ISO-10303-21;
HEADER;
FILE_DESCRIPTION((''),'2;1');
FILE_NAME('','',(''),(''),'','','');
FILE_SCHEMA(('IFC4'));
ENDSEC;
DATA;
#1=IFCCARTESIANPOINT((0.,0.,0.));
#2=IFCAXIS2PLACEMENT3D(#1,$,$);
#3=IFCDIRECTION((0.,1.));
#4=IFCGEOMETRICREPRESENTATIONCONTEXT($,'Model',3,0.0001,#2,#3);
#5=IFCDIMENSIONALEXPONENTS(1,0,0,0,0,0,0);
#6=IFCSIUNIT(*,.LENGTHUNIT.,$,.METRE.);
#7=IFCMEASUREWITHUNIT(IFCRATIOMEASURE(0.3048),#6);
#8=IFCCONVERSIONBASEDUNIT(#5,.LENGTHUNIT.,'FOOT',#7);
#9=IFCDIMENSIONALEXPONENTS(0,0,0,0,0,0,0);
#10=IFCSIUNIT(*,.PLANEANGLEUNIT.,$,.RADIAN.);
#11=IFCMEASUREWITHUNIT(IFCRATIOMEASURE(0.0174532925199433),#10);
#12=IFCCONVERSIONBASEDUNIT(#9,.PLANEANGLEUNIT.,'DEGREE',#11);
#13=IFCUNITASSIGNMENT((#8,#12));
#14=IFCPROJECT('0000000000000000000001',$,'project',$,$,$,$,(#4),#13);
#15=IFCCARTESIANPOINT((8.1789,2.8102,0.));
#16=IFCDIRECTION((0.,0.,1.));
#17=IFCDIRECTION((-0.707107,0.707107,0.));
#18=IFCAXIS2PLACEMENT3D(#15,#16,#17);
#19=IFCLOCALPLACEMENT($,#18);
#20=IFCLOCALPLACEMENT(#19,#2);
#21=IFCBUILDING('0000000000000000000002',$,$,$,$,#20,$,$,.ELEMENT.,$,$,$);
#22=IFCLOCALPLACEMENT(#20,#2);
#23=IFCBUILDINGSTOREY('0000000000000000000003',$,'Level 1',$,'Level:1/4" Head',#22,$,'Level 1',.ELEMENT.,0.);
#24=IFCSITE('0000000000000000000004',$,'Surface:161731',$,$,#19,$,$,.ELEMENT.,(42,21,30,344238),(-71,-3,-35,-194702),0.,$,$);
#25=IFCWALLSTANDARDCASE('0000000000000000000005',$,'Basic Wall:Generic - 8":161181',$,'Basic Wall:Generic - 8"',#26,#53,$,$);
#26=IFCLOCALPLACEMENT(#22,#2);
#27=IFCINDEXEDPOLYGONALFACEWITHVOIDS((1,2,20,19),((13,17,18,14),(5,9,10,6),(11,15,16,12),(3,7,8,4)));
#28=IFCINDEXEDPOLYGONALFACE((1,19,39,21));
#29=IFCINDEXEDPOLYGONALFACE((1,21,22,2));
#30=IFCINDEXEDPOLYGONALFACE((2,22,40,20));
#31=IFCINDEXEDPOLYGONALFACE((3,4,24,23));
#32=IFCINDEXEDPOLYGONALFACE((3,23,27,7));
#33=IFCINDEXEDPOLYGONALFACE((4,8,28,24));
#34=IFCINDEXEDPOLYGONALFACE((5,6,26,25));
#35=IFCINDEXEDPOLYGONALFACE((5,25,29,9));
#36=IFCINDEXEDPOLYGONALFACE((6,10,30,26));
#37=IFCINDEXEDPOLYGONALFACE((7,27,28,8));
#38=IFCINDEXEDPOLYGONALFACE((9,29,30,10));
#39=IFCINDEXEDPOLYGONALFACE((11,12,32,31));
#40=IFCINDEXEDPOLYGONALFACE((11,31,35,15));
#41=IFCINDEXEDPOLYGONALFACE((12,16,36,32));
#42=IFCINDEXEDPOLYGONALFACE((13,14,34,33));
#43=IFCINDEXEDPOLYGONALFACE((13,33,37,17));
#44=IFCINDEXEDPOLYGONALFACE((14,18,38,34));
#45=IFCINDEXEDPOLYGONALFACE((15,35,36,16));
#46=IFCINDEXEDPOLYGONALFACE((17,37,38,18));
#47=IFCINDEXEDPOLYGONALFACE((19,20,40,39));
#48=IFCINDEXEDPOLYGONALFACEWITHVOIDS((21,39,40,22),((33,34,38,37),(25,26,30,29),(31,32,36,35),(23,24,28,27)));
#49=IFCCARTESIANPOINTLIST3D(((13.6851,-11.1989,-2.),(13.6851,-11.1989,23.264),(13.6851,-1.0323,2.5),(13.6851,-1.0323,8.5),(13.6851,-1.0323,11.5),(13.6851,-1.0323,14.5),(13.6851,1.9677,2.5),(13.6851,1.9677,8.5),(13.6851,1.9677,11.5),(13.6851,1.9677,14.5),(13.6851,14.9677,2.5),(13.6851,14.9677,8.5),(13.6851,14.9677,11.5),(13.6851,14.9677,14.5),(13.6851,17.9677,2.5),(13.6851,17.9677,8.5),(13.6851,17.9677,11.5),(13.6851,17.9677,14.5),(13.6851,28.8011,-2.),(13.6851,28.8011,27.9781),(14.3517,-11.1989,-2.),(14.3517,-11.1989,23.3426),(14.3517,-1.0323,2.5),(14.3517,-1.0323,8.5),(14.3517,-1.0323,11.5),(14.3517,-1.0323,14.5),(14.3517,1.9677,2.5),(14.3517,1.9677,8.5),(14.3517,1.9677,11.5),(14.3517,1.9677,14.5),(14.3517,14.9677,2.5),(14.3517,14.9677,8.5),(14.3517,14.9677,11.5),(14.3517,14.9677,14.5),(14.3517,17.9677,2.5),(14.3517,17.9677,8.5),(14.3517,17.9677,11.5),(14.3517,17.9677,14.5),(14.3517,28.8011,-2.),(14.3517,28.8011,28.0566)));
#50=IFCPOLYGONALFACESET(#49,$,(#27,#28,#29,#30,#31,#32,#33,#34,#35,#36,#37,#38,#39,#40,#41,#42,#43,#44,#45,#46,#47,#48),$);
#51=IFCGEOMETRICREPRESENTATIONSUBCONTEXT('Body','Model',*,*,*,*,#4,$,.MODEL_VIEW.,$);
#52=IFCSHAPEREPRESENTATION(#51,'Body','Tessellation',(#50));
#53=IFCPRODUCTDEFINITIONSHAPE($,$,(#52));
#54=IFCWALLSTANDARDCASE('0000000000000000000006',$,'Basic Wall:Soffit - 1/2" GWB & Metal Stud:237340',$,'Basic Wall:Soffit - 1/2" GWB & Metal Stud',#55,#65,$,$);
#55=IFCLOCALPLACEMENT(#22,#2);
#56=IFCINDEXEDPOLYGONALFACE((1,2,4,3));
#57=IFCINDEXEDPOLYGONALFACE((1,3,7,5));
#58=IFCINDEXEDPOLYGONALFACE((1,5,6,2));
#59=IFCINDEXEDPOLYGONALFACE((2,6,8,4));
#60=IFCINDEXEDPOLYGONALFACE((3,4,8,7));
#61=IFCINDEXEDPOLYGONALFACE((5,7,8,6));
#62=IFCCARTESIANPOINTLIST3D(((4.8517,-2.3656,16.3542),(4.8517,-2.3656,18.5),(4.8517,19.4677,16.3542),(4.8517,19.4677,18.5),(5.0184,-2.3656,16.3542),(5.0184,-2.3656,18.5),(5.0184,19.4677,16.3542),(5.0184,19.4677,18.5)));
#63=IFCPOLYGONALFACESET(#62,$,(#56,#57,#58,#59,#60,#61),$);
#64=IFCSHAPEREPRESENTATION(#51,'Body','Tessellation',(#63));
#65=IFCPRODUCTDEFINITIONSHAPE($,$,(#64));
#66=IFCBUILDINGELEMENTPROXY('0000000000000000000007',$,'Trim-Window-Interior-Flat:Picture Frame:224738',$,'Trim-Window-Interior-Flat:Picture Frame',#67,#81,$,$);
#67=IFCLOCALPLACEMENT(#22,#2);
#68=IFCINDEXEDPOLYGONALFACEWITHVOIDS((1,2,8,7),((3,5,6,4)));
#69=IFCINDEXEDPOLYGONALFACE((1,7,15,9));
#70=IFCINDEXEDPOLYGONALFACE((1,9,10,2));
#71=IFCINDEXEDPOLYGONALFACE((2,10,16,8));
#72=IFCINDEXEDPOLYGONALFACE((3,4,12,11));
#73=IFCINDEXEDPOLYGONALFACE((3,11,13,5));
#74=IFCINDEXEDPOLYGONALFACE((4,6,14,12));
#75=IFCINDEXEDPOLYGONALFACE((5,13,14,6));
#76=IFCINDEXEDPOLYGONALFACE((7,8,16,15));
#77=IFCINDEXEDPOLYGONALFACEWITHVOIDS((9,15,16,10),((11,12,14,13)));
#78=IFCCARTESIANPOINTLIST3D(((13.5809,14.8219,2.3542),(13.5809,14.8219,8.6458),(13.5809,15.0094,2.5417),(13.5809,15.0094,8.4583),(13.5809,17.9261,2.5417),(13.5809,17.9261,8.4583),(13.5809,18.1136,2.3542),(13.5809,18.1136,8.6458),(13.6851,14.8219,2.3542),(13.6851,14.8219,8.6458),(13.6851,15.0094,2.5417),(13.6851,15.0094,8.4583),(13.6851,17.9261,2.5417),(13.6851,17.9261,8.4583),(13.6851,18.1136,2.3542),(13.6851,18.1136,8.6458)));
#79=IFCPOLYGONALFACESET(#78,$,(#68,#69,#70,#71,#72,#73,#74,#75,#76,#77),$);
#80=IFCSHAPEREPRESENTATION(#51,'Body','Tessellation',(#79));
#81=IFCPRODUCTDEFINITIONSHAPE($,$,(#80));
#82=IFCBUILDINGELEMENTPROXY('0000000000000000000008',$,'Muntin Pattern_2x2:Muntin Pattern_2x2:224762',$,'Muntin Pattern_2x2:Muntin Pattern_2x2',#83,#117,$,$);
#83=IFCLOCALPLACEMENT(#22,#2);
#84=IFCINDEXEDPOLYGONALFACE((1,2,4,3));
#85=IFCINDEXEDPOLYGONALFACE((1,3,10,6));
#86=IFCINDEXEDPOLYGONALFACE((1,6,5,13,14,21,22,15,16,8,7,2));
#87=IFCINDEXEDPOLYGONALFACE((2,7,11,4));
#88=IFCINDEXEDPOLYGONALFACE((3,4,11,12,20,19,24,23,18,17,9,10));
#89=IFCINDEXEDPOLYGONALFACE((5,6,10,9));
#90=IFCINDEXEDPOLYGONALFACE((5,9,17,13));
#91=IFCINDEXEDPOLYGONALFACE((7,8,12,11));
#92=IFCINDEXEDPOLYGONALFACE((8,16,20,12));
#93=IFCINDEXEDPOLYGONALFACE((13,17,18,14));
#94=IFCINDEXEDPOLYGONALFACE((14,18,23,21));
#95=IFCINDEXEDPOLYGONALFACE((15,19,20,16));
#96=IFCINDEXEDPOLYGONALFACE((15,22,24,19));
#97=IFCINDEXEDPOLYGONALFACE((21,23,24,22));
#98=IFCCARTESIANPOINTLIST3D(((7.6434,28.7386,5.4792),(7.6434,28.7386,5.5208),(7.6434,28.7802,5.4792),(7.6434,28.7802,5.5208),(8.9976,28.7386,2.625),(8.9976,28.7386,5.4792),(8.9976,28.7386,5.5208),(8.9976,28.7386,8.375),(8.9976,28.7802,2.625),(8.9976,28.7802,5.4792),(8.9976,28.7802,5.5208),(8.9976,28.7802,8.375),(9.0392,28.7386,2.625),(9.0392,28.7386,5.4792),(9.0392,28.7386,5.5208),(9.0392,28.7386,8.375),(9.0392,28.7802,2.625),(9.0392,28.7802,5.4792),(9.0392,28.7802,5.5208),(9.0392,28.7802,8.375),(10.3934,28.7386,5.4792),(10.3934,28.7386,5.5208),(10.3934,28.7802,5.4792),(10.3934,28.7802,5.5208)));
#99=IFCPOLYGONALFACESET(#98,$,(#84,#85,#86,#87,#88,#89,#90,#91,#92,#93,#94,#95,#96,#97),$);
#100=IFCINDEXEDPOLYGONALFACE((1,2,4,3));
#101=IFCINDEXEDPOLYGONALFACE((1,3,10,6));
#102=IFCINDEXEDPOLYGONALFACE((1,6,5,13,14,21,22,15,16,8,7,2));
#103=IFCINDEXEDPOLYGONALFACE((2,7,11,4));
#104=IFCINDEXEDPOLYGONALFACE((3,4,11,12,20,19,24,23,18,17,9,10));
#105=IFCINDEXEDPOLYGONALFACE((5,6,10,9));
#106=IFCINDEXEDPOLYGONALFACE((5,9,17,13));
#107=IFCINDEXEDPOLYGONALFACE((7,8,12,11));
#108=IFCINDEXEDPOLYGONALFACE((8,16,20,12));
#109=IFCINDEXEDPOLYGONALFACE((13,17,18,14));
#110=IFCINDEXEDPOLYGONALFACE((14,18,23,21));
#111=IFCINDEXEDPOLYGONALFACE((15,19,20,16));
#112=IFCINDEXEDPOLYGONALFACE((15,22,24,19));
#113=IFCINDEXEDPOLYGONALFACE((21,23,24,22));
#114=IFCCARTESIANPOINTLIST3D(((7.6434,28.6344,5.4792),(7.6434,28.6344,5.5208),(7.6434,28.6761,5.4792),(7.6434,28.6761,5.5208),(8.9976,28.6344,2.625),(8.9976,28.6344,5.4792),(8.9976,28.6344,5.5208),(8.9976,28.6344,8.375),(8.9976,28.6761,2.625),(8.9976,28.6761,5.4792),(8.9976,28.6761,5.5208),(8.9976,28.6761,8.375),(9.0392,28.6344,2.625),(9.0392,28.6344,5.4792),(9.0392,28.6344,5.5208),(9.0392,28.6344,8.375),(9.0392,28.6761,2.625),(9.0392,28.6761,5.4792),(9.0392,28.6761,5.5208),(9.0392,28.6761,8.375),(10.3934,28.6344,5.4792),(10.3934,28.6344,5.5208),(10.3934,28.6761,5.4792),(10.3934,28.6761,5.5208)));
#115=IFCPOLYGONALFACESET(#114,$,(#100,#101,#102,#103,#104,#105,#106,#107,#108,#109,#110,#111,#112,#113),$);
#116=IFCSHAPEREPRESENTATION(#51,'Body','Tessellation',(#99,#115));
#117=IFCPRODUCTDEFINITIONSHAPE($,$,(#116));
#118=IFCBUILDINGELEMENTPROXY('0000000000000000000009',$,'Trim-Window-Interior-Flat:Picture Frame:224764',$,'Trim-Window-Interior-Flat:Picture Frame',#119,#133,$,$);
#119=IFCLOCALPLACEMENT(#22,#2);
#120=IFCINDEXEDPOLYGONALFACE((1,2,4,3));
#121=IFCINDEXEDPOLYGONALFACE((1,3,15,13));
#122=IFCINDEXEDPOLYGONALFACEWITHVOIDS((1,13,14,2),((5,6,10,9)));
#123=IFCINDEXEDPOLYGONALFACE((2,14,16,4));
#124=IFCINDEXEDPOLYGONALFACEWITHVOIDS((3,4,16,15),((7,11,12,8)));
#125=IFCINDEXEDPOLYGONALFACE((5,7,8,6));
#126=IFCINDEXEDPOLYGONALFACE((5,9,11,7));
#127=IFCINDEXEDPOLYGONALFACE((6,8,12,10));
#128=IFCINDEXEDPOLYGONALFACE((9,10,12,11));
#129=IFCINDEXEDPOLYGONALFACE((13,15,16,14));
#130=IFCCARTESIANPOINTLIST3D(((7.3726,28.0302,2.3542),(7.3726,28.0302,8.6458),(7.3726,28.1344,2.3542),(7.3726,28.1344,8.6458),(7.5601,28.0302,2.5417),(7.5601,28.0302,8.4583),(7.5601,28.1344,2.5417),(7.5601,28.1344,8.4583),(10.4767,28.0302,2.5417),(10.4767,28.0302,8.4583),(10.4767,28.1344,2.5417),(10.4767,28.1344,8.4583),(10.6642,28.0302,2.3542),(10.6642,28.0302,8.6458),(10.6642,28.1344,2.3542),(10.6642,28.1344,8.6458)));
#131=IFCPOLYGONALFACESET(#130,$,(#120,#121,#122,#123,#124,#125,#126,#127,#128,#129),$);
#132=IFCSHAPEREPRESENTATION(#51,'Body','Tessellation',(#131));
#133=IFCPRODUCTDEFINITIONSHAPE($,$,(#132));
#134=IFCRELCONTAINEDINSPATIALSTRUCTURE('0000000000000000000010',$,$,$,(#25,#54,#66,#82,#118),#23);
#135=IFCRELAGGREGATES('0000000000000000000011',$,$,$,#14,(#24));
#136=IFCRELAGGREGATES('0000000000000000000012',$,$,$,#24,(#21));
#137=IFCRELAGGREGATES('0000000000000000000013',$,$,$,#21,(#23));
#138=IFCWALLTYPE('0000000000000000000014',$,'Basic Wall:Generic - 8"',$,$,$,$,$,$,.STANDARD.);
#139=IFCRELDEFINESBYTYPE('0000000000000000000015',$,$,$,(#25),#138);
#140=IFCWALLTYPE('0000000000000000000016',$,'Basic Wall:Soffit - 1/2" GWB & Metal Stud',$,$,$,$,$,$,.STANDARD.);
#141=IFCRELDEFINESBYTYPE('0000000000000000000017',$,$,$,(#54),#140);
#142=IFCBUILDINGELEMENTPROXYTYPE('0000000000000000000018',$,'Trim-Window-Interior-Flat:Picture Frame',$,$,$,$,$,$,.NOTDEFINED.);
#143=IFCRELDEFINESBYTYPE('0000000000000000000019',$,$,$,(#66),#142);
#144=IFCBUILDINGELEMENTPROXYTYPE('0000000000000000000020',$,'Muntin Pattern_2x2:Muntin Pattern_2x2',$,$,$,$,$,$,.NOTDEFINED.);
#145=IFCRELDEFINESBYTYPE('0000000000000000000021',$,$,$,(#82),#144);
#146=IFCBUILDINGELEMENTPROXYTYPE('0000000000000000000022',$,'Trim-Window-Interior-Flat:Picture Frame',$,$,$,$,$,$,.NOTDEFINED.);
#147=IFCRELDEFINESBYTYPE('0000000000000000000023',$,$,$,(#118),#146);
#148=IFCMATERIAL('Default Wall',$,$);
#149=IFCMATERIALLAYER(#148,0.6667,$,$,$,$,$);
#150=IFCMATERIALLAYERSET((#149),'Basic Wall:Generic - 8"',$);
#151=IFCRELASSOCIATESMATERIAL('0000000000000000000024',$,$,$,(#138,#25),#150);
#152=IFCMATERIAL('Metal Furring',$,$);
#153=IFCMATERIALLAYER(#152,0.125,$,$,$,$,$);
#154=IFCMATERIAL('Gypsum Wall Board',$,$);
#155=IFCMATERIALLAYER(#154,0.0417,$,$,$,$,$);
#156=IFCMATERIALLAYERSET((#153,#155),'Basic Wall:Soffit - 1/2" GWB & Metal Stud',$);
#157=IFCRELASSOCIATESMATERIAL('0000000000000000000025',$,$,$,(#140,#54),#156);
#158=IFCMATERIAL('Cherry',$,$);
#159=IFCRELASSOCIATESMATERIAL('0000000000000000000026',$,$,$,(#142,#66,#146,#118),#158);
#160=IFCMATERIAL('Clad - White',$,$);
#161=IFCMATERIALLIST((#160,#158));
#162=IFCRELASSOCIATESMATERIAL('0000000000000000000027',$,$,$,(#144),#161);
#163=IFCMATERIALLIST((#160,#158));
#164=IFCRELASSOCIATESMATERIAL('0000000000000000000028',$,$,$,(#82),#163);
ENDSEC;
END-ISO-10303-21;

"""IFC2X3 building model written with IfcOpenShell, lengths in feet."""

from ifc_helpers import new_model, entity, si_unit, converted_unit, direction, frame, frame_2d, origin, place, context, subcontext, project, spatial, polyline, rectangle, outline, extrude, clip, bounded_halfspace, source, transform, mapped, material, material_list, layer, layer_set, layer_usage, type_object, type_shapes, element, save


model = new_model("IFC2X3")

# Units and contexts
model_context = context("Model", 3, precision=0.0001, world=origin(), true_north=direction((0.0, 1.0)))
body_context = subcontext(model_context, "Body", "Model", "MODEL_VIEW")
ifc_project = project(units=[converted_unit("LENGTHUNIT", "FOOT", entity("IfcRatioMeasure", 0.3048), si_unit("LENGTHUNIT", "METRE"), dimensions=[1, 0, 0, 0, 0, 0, 0]), converted_unit("PLANEANGLEUNIT", "DEGREE", entity("IfcRatioMeasure", 0.0174532925199433), si_unit("PLANEANGLEUNIT", "RADIAN"), dimensions=[0, 0, 0, 0, 0, 0, 0])], contexts=[model_context])

# Site, building, storey
site_placement = place(None, frame((8.1789, 2.8102, 0.0), z_axis=(0.0, 0.0, 1.0), x_axis=(-0.707107, 0.707107, 0.0)))
site = spatial("IfcSite", under=ifc_project, at=site_placement, Name="Surface:161731", CompositionType="ELEMENT", RefLatitude=(42, 21, 30, 344238), RefLongitude=(-71, -3, -35, -194702), RefElevation=0.0)
building_placement = place(site_placement, origin())
building = spatial("IfcBuilding", under=site, at=building_placement, CompositionType="ELEMENT")
storey_placement = place(building_placement, origin())
storey = spatial("IfcBuildingStorey", under=building, at=storey_placement, Name="Level 1", ObjectType="Level:1/4\" Head", LongName="Level 1", CompositionType="ELEMENT", Elevation=0.0)

# Wall, openings
ifc_material_1 = material(Name="Default Wall")
ifc_layer_1 = layer(ifc_material_1, 0.6667)
ifc_layer_set_1 = layer_set([ifc_layer_1], Name="Basic Wall:Generic - 8\"")
ifc_layer_usage_1 = layer_usage(ifc_layer_set_1, "AXIS2", "NEGATIVE", 0.3333)
wall_type_1 = type_object("IfcWallType", Name="Basic Wall:Generic - 8\"", PredefinedType="STANDARD", material=ifc_layer_set_1)
wall_1_placement = place(storey_placement, frame((14.0184, 28.8011, -2.0), z_axis=(0.0, 0.0, 1.0), x_axis=(0.0, -1.0, 0.0)))
wall_1 = element("IfcWallStandardCase", 1, at=wall_1_placement, inside=storey, type_object=wall_type_1, material=ifc_layer_usage_1, Name="Basic Wall:Generic - 8\":161181", ObjectType="Basic Wall:Generic - 8\"", context=body_context, shape_type="Clipping", body=[
    clip(extrude(rectangle(XDim=40.0, YDim=0.6667, at=frame_2d((20.0, 0.0), x_axis=(-1.0, 0.0))), origin(), (0.0, 0.0, 1.0), 30.0566), bounded_halfspace(frame((0.0, -0.3333, 29.9781), z_axis=(0.116248, -0.116248, 0.986394), x_axis=(0.707107, 0.707107, 0.0)), False, frame((0.0, -0.3333, 29.9781)), polyline([(0.0, 0.0), (0.6667, 0.0), (40.0, 0.0), (40.0, 0.6667), (0.0, 0.6667), (0.0, 0.0)]))),
])
opening_1_placement = place(wall_1_placement, frame((26.8333, -0.3333, 4.5)))
element("IfcOpeningElement", 2, at=opening_1_placement, cuts=wall_1, ObjectType="Opening", context=body_context, shape_type="SweptSolid", body=[
    extrude(rectangle(XDim=6.0, YDim=3.0, at=frame_2d((3.0, 1.5), x_axis=(-1.0, 0.0))), frame((0.0, 0.0, 0.0), z_axis=(0.0, 1.0, 0.0), x_axis=(0.0, 0.0, 1.0)), (0.0, 0.0, 1.0), 0.6667),
])
opening_2_placement = place(wall_1_placement, frame((10.8333, -0.3333, 4.5)))
element("IfcOpeningElement", 3, at=opening_2_placement, cuts=wall_1, ObjectType="Opening", context=body_context, shape_type="SweptSolid", body=[
    extrude(rectangle(XDim=6.0, YDim=3.0, at=frame_2d((3.0, 1.5), x_axis=(-1.0, 0.0))), frame((0.0, 0.0, 0.0), z_axis=(0.0, 1.0, 0.0), x_axis=(0.0, 0.0, 1.0)), (0.0, 0.0, 1.0), 0.6667),
])
opening_3_placement = place(wall_1_placement, frame((26.8333, -0.3333, 13.5)))
element("IfcOpeningElement", 4, at=opening_3_placement, cuts=wall_1, ObjectType="Opening", context=body_context, shape_type="SweptSolid", body=[
    extrude(rectangle(XDim=3.0, YDim=3.0, at=frame_2d((1.5, 1.5), x_axis=(-1.0, 0.0))), frame((0.0, 0.0, 0.0), z_axis=(0.0, 1.0, 0.0), x_axis=(0.0, 0.0, 1.0)), (0.0, 0.0, 1.0), 0.6667),
])
opening_4_placement = place(wall_1_placement, frame((10.8333, -0.3333, 13.5)))
element("IfcOpeningElement", 5, at=opening_4_placement, cuts=wall_1, ObjectType="Opening", context=body_context, shape_type="SweptSolid", body=[
    extrude(rectangle(XDim=3.0, YDim=3.0, at=frame_2d((1.5, 1.5), x_axis=(-1.0, 0.0))), frame((0.0, 0.0, 0.0), z_axis=(0.0, 1.0, 0.0), x_axis=(0.0, 0.0, 1.0)), (0.0, 0.0, 1.0), 0.6667),
])

# Wall
ifc_material_2 = material(Name="Metal Furring")
ifc_layer_2 = layer(ifc_material_2, 0.125)
ifc_material_3 = material(Name="Gypsum Wall Board")
ifc_layer_3 = layer(ifc_material_3, 0.0417)
ifc_layer_set_2 = layer_set([ifc_layer_2, ifc_layer_3], Name="Basic Wall:Soffit - 1/2\" GWB & Metal Stud")
ifc_layer_usage_2 = layer_usage(ifc_layer_set_2, "AXIS2", "POSITIVE", -0.0833)
wall_type_2 = type_object("IfcWallType", Name="Basic Wall:Soffit - 1/2\" GWB & Metal Stud", PredefinedType="STANDARD", material=ifc_layer_set_2)
wall_2_placement = place(storey_placement, frame((4.9351, 19.4677, 16.3542), z_axis=(0.0, 0.0, 1.0), x_axis=(0.0, -1.0, 0.0)))
element("IfcWallStandardCase", 6, at=wall_2_placement, inside=storey, type_object=wall_type_2, material=ifc_layer_usage_2, Name="Basic Wall:Soffit - 1/2\" GWB & Metal Stud:237340", ObjectType="Basic Wall:Soffit - 1/2\" GWB & Metal Stud", context=body_context, shape_type="Clipping", body=[
    clip(extrude(rectangle(XDim=21.8333, YDim=0.1667, at=frame_2d((10.9167, 0.0), x_axis=(-1.0, 0.0))), origin(), (0.0, 0.0, 1.0), 2.1458), bounded_halfspace(frame((21.8333, -0.0833, 0.0)), True, frame((21.8333, -0.0833, 0.0)), polyline([(0.0, 0.0), (0.0, 0.1667), (-21.8333, 0.1667), (-21.8333, 0.0), (-21.6667, 0.0), (0.0, 0.0)]))),
])

# Building element proxies
ifc_material_4 = material(Name="Cherry")
building_element_proxy_type_1 = type_object("IfcBuildingElementProxyType", Name="Trim-Window-Interior-Flat:Picture Frame", PredefinedType="NOTDEFINED", material=ifc_material_4)
shared_shape_1 = source(origin(), body_context, "Body", "SweptSolid", [
    extrude(outline(polyline([(-3.1458, -1.6458), (3.1458, -1.6458), (3.1458, 1.6458), (-3.1458, 1.6458), (-3.1458, -1.6458)]), holes=[polyline([(-2.9583, -1.4583), (-2.9583, 1.4583), (2.9583, 1.4583), (2.9583, -1.4583), (-2.9583, -1.4583)])]), frame((0.0, 3.0, 0.0), z_axis=(0.0, 0.0, 1.0), x_axis=(0.0, 1.0, 0.0)), (0.0, 0.0, 1.0), 0.1042),
])
type_shapes(building_element_proxy_type_1, [shared_shape_1])
proxy_1_placement = place(storey_placement, frame((13.6851, 16.4677, 8.5), z_axis=(-1.0, 0.0, 0.0), x_axis=(0.0, 1.0, 0.0)))
element("IfcBuildingElementProxy", 7, at=proxy_1_placement, inside=storey, type_object=building_element_proxy_type_1, material=ifc_material_4, Name="Trim-Window-Interior-Flat:Picture Frame:224738", ObjectType="Trim-Window-Interior-Flat:Picture Frame", context=body_context, shape_type="MappedRepresentation", body=[
    mapped(shared_shape_1, transform((0.0, 0.0, 0.0), scale=1.0)),
])
ifc_material_5 = material(Name="Clad - White")
ifc_material_list_1 = material_list([ifc_material_5, ifc_material_4])
ifc_material_list_2 = material_list([ifc_material_5, ifc_material_4])
building_element_proxy_type_2 = type_object("IfcBuildingElementProxyType", Name="Muntin Pattern_2x2:Muntin Pattern_2x2", PredefinedType="NOTDEFINED", material=ifc_material_list_2)
shared_shape_2 = source(origin(), body_context, "Body", "SweptSolid", [
    extrude(outline(polyline([(0.0208, -0.0208), (2.875, -0.0208), (2.875, 0.0208), (0.0208, 0.0208), (0.0208, 1.375), (-0.0208, 1.375), (-0.0208, 0.0208), (-2.875, 0.0208), (-2.875, -0.0208), (-0.0208, -0.0208), (-0.0208, -1.375), (0.0208, -1.375), (0.0208, -0.0208)])), frame((0.0, -0.0729, 2.875), z_axis=(0.0, 1.0, 0.0), x_axis=(0.0, 0.0, 1.0)), (0.0, 0.0, 1.0), 0.0417),
    extrude(outline(polyline([(0.0208, -0.0208), (2.875, -0.0208), (2.875, 0.0208), (0.0208, 0.0208), (0.0208, 1.375), (-0.0208, 1.375), (-0.0208, 0.0208), (-2.875, 0.0208), (-2.875, -0.0208), (-0.0208, -0.0208), (-0.0208, -1.375), (0.0208, -1.375), (0.0208, -0.0208)])), frame((0.0, 0.0313, 2.875), z_axis=(0.0, 1.0, 0.0), x_axis=(0.0, 0.0, 1.0)), (0.0, 0.0, 1.0), 0.0417),
])
type_shapes(building_element_proxy_type_2, [shared_shape_2])
proxy_2_placement = place(storey_placement, frame((9.0184, 28.7073, 2.625), z_axis=(0.0, 0.0, 1.0), x_axis=(-1.0, 0.0, 0.0)))
element("IfcBuildingElementProxy", 8, at=proxy_2_placement, inside=storey, type_object=building_element_proxy_type_2, material=ifc_material_list_1, Name="Muntin Pattern_2x2:Muntin Pattern_2x2:224762", ObjectType="Muntin Pattern_2x2:Muntin Pattern_2x2", context=body_context, shape_type="MappedRepresentation", body=[
    mapped(shared_shape_2, transform((0.0, 0.0, 0.0), scale=1.0)),
])
building_element_proxy_type_3 = type_object("IfcBuildingElementProxyType", Name="Trim-Window-Interior-Flat:Picture Frame", PredefinedType="NOTDEFINED", material=ifc_material_4)
shared_shape_3 = source(origin(), body_context, "Body", "SweptSolid", [
    extrude(outline(polyline([(-1.6458, -3.1458), (1.6458, -3.1458), (1.6458, 3.1458), (-1.6458, 3.1458), (-1.6458, -3.1458)]), holes=[polyline([(-1.4583, -2.9583), (-1.4583, 2.9583), (1.4583, 2.9583), (1.4583, -2.9583), (-1.4583, -2.9583)])]), frame((0.0, -3.0, 0.0), z_axis=(0.0, 0.0, 1.0), x_axis=(-1.0, 0.0, 0.0)), (0.0, 0.0, 1.0), 0.1042),
])
type_shapes(building_element_proxy_type_3, [shared_shape_3])
proxy_3_placement = place(storey_placement, frame((9.0184, 28.1344, 8.5), z_axis=(0.0, -1.0, 0.0), x_axis=(1.0, 0.0, 0.0)))
element("IfcBuildingElementProxy", 9, at=proxy_3_placement, inside=storey, type_object=building_element_proxy_type_3, material=ifc_material_4, Name="Trim-Window-Interior-Flat:Picture Frame:224764", ObjectType="Trim-Window-Interior-Flat:Picture Frame", context=body_context, shape_type="MappedRepresentation", body=[
    mapped(shared_shape_3, transform((0.0, 0.0, 0.0), scale=1.0)),
])

save(model, "model.ifc")
